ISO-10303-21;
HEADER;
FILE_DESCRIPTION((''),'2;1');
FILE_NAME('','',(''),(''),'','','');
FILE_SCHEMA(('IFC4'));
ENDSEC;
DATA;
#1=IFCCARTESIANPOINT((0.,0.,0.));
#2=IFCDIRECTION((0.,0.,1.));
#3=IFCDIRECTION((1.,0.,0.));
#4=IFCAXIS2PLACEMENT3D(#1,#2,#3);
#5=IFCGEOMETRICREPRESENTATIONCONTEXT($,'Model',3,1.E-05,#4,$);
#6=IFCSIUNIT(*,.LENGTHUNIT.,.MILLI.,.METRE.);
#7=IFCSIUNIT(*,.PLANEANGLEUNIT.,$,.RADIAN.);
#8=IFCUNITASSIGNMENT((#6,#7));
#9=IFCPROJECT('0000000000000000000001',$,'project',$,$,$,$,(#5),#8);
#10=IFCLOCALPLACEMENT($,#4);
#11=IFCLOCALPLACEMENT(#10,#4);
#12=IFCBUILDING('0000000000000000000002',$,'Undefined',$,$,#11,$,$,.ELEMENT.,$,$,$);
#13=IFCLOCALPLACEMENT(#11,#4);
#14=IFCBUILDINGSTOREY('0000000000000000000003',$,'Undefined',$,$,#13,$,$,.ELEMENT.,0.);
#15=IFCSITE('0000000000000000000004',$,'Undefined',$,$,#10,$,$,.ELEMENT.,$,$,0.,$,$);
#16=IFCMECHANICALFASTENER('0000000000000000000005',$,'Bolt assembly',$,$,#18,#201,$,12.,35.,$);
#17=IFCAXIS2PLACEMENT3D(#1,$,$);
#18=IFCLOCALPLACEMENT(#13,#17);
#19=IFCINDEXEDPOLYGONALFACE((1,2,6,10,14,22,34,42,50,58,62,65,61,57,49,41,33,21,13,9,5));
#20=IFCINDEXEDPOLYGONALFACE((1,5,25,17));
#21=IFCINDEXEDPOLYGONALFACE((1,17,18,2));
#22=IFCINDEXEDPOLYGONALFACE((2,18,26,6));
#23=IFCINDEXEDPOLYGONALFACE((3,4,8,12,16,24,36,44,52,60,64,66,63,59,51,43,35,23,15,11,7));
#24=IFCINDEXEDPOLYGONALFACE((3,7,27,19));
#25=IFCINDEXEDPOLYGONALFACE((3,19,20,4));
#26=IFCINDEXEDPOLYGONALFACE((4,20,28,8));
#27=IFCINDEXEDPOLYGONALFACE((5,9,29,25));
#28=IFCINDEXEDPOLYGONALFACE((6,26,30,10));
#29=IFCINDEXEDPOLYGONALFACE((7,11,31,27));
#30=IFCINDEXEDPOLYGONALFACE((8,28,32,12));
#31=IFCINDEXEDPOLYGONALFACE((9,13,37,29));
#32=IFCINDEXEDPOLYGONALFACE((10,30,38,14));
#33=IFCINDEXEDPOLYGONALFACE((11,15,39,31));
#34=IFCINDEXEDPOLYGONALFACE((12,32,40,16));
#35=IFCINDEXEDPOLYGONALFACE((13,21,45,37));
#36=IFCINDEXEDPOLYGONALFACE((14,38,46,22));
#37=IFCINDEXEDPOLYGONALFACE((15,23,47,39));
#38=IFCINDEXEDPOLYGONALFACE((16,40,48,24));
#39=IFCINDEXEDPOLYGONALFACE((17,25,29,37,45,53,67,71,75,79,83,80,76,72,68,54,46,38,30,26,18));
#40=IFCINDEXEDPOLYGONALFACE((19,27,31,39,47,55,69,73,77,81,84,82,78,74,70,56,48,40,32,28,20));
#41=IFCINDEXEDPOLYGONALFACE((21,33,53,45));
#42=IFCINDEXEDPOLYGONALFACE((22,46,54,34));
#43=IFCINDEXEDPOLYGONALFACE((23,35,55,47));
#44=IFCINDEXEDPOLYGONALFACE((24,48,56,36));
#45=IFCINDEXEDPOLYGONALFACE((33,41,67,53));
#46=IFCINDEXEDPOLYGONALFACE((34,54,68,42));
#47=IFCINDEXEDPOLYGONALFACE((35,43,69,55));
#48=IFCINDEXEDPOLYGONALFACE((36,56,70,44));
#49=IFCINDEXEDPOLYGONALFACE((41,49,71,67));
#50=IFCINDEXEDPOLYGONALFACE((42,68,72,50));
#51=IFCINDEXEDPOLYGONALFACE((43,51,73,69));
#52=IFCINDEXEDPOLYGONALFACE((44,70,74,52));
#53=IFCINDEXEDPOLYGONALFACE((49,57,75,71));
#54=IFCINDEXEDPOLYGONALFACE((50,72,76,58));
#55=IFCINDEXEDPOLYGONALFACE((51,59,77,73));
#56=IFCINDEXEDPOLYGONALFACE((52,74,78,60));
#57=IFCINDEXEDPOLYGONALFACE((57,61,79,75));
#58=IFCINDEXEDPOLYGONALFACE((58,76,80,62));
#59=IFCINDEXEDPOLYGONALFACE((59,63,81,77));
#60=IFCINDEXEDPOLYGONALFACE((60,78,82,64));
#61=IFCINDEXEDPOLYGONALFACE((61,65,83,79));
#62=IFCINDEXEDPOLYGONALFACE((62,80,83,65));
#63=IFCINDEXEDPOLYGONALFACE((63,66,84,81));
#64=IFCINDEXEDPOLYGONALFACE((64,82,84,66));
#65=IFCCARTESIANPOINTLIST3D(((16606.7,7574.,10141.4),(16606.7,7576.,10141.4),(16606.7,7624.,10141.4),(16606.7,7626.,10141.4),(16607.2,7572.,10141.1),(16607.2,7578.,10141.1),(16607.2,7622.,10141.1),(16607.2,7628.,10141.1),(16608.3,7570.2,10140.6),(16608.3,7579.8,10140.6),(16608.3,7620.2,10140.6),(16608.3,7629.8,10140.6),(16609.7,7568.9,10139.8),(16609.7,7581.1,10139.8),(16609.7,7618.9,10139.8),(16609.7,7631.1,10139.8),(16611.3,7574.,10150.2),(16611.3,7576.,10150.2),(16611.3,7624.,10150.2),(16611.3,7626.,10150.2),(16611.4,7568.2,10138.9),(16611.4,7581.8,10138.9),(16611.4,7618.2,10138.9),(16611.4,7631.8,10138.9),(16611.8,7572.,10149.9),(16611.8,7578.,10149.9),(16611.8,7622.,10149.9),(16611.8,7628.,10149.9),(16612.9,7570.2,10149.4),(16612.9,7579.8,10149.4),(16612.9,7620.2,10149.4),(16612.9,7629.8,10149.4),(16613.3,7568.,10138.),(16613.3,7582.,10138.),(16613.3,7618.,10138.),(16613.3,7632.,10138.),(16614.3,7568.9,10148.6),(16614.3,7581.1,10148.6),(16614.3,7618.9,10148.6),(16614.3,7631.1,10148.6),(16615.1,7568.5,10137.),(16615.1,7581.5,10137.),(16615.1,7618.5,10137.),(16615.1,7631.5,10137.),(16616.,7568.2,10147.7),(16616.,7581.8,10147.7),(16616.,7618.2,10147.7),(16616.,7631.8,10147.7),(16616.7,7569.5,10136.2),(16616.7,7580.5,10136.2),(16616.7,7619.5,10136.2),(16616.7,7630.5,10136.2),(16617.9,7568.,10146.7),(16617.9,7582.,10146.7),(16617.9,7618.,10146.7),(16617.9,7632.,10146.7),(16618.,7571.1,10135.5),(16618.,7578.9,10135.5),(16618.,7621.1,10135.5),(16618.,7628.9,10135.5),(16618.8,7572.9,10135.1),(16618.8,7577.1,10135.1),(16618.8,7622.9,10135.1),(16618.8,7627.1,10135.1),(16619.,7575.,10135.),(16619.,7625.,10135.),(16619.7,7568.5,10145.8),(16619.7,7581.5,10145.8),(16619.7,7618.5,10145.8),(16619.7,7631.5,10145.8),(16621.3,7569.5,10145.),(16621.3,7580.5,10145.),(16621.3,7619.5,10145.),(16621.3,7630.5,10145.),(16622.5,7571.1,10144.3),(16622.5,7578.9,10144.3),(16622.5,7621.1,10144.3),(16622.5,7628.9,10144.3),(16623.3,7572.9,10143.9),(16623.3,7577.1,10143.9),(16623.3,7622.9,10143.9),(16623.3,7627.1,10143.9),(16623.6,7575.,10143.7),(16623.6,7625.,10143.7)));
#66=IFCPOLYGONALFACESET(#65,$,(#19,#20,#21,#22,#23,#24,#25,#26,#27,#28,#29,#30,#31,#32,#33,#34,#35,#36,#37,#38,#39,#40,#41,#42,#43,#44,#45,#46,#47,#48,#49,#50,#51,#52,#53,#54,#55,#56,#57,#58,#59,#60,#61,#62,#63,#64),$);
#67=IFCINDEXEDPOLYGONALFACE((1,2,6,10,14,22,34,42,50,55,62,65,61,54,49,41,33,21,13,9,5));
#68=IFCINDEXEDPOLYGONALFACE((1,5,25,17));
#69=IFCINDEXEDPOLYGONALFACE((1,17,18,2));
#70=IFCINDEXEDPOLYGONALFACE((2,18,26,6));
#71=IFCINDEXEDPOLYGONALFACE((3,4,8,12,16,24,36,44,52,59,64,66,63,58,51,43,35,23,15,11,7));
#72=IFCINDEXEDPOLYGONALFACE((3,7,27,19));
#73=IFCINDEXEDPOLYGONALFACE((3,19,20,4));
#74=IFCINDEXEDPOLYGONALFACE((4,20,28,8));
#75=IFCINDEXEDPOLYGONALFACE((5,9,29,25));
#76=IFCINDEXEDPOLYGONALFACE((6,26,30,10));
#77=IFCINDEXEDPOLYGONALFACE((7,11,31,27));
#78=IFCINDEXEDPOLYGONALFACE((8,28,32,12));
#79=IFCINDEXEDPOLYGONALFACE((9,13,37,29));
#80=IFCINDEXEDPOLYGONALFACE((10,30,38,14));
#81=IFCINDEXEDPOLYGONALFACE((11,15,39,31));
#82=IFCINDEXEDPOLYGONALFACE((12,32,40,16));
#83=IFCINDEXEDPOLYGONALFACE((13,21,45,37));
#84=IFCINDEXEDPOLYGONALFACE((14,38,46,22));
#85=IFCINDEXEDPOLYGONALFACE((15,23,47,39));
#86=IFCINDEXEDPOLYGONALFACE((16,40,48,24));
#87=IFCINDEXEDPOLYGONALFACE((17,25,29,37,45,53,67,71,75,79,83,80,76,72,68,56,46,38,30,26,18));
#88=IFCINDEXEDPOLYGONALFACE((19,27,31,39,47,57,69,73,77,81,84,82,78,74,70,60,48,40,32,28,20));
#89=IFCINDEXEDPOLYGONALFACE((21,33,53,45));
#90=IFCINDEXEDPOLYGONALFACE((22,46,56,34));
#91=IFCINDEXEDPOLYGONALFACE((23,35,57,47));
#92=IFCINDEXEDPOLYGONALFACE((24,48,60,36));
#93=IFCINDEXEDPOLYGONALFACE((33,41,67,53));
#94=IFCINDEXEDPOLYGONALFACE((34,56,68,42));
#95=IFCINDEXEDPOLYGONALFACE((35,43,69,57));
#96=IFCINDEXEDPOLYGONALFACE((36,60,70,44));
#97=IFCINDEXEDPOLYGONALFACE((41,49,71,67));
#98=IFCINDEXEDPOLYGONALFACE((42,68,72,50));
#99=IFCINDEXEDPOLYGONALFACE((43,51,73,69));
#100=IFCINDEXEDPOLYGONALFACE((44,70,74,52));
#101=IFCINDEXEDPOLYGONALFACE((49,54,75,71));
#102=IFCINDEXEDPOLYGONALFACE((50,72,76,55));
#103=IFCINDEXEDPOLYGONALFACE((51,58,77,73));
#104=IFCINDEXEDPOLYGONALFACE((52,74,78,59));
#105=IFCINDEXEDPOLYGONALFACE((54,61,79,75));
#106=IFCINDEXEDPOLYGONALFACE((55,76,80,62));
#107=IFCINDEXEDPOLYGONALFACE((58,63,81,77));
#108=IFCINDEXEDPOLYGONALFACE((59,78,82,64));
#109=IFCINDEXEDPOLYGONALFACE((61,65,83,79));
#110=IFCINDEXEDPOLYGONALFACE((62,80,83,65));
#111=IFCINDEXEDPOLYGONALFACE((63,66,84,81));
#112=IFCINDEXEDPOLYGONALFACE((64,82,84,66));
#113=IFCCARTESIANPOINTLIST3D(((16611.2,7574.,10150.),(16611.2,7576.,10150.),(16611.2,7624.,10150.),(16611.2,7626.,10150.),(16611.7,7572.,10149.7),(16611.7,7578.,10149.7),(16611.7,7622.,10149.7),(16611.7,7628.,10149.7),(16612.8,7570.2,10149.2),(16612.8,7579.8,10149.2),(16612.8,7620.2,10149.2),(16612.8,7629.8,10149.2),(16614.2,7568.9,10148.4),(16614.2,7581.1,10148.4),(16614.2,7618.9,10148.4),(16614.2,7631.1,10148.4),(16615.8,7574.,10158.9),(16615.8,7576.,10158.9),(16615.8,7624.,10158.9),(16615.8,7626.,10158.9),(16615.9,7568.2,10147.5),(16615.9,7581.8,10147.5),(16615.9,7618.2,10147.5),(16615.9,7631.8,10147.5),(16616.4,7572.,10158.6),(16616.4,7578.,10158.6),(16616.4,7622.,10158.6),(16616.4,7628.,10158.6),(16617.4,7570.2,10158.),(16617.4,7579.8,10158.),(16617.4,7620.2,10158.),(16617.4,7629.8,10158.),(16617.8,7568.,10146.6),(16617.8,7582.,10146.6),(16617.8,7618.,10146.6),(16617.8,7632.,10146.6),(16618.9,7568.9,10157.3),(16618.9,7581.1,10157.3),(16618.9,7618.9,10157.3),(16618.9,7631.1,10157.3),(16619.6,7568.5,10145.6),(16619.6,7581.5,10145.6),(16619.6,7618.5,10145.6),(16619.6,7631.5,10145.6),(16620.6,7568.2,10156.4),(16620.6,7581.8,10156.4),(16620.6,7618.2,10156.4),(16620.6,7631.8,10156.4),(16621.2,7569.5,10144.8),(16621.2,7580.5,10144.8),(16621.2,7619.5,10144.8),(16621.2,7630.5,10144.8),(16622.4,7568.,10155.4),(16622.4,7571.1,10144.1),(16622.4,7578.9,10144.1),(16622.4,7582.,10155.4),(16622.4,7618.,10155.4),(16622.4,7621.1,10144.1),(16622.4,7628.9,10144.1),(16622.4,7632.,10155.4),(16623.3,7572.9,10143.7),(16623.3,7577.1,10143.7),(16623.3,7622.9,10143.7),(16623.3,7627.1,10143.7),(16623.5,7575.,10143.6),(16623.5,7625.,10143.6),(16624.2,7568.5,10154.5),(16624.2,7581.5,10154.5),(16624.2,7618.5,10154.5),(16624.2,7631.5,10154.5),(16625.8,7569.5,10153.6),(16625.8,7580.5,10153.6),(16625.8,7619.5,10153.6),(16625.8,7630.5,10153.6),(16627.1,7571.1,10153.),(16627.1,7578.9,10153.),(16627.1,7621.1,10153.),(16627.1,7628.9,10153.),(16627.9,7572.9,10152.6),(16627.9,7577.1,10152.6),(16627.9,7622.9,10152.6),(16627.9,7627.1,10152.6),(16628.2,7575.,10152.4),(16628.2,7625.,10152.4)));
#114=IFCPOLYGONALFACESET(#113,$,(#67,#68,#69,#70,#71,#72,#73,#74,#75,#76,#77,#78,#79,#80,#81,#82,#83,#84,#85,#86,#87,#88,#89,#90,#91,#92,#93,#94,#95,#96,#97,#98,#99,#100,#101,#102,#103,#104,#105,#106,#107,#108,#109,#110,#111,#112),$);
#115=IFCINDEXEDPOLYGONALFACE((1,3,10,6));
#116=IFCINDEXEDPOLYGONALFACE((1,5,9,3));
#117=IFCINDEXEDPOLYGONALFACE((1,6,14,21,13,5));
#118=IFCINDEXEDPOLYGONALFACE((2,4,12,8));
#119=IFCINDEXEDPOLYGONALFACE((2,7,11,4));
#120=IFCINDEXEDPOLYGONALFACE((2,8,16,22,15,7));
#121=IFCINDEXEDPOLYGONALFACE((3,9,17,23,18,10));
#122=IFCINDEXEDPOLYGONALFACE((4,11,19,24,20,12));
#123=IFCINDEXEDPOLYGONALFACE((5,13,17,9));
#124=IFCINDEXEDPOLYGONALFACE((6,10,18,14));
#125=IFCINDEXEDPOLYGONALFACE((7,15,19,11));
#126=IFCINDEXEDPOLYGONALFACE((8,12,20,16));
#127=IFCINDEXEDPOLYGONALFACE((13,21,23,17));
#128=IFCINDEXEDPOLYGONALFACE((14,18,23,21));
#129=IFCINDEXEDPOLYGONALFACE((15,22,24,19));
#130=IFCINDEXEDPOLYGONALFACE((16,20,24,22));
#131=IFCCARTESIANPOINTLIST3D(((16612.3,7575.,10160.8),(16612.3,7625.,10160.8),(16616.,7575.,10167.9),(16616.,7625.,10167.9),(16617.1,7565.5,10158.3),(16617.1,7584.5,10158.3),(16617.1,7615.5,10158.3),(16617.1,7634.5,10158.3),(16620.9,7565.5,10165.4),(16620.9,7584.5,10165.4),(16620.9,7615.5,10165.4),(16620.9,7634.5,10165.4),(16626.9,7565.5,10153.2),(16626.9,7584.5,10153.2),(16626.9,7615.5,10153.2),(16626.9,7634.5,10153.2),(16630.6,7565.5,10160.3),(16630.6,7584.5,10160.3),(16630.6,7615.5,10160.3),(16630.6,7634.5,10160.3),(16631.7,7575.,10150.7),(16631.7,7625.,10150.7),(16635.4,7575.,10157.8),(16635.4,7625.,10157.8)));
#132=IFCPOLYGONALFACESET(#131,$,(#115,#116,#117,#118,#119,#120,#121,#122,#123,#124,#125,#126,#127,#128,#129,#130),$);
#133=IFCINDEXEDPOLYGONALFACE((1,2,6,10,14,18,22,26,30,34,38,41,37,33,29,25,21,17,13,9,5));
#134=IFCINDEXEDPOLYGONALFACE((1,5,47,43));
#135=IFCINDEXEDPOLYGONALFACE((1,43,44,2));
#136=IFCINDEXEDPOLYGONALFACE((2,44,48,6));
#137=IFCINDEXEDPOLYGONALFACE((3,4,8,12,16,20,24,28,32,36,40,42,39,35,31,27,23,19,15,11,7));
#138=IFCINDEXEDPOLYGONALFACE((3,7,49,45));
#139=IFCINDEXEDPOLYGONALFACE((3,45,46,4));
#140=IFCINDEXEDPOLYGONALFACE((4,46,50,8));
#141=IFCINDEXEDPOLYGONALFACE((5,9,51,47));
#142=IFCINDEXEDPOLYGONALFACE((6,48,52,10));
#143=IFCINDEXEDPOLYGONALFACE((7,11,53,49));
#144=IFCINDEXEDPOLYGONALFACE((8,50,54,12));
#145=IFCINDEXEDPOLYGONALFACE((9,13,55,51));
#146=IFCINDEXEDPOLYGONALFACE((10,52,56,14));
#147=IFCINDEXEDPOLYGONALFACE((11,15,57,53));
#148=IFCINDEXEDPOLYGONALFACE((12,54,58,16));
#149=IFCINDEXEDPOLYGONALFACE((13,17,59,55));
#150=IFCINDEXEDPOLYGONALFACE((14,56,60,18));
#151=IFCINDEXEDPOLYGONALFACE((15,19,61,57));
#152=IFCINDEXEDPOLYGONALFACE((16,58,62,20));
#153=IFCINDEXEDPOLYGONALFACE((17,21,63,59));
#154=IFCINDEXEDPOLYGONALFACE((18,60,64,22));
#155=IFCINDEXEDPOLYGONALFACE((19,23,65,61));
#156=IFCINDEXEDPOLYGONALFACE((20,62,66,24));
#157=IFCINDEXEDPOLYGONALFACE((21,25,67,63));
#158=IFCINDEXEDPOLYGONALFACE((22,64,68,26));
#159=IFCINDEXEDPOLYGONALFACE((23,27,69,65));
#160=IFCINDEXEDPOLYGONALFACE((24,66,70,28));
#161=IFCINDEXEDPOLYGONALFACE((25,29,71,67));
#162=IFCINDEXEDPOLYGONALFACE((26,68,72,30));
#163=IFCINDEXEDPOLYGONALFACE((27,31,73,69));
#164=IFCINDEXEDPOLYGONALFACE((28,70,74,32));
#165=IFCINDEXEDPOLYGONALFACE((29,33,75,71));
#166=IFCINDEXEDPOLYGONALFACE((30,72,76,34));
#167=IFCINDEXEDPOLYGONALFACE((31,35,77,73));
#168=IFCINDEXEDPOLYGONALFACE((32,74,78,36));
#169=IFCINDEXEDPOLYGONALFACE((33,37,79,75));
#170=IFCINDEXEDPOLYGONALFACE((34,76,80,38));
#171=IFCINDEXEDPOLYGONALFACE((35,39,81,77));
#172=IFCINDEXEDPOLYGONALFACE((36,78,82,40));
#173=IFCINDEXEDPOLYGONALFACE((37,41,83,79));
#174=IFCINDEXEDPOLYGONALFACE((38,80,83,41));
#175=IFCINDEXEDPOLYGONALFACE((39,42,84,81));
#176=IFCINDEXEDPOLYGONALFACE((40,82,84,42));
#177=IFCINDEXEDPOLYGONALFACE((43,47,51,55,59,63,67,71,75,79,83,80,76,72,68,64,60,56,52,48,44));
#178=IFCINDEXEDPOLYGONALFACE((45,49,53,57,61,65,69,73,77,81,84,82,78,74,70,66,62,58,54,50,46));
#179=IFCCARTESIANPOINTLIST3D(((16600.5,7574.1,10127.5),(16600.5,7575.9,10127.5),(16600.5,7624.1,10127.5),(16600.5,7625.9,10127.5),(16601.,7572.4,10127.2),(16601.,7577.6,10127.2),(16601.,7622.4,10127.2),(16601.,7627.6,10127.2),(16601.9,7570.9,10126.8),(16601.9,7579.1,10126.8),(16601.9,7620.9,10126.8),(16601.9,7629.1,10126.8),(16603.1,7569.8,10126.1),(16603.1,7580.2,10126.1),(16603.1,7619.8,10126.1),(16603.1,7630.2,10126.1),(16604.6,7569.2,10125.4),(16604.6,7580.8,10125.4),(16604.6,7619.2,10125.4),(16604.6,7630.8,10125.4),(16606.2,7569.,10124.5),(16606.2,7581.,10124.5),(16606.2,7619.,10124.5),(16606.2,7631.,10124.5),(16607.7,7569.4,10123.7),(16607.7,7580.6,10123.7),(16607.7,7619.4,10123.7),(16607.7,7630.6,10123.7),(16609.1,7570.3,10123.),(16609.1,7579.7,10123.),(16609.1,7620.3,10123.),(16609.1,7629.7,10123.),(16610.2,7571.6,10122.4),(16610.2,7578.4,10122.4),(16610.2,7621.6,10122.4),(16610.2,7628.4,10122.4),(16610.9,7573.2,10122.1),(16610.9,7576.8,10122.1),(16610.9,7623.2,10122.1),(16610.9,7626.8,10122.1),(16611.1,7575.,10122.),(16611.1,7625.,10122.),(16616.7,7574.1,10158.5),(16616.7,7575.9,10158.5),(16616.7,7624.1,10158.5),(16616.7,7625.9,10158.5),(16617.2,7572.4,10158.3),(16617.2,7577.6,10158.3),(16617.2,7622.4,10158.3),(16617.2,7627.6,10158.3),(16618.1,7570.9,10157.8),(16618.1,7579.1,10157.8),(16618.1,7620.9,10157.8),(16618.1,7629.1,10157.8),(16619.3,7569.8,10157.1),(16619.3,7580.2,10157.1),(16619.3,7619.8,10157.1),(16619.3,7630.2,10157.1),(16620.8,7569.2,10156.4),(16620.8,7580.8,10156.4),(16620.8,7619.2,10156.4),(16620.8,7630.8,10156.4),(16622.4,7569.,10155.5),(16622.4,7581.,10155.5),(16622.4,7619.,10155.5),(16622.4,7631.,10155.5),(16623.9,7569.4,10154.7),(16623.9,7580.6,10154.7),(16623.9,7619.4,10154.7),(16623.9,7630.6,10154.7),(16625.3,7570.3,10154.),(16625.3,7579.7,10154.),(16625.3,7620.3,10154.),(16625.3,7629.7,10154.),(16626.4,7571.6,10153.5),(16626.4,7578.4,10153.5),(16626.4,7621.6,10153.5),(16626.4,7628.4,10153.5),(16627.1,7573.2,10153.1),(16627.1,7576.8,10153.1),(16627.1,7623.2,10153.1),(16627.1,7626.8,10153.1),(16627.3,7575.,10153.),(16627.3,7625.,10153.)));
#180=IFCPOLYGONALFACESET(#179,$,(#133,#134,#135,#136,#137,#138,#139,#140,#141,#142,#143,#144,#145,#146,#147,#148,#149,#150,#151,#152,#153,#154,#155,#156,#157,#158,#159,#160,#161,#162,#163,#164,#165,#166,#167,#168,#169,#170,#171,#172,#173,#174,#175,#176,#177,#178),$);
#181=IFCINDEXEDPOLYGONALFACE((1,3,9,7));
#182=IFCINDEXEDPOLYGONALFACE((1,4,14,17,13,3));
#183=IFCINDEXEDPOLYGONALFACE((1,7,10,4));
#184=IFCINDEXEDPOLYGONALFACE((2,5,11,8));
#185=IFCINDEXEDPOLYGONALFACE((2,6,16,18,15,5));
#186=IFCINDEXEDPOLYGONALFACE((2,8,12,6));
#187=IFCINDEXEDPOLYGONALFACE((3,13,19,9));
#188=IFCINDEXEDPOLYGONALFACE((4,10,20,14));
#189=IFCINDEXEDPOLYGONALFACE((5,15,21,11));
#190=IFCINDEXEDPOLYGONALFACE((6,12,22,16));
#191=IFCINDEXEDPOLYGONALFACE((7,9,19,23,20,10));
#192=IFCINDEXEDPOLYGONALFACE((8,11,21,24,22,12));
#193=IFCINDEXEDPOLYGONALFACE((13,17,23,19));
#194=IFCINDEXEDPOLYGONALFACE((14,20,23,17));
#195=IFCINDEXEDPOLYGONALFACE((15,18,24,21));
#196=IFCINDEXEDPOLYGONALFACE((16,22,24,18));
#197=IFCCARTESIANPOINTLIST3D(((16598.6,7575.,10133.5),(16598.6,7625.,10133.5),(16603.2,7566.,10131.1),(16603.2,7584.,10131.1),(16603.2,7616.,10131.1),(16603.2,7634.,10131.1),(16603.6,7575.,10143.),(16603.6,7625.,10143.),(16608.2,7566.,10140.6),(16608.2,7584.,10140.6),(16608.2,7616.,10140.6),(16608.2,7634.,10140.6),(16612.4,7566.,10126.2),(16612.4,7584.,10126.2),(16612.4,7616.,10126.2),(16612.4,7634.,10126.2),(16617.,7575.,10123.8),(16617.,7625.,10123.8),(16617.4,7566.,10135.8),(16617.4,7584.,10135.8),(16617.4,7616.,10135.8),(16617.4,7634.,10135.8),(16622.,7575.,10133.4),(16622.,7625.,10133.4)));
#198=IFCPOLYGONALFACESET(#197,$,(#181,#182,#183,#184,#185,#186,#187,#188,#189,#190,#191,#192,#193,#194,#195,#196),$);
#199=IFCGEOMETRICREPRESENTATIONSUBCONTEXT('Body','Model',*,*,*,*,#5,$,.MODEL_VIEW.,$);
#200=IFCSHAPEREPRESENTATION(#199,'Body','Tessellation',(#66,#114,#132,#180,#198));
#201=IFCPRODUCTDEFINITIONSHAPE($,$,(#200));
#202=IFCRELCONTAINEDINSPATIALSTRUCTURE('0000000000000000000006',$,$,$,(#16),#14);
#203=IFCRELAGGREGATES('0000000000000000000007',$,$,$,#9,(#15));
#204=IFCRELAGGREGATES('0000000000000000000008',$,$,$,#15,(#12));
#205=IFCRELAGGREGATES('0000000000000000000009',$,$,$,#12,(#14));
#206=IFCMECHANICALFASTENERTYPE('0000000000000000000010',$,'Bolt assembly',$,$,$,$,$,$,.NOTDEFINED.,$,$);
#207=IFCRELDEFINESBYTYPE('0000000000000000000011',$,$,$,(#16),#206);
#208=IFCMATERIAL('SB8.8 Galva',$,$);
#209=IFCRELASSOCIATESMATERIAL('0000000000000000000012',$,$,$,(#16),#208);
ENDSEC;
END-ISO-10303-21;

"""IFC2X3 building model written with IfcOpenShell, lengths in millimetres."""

from ifc_helpers import new_model, si_unit, frame, origin_with_axes, origin_2d_with_axis, place, context, subcontext, project, spatial, polyline, circle, outline, extrude, source, transform, mapped, material, type_object, element, save


model = new_model("IFC2X3")

# Units and contexts
model_context = context("Model", 3, precision=1e-05, world=origin_with_axes())
body_context = subcontext(model_context, "Body", "Model", "MODEL_VIEW")
ifc_project = project(units=[si_unit("LENGTHUNIT", "METRE", prefix="MILLI"), si_unit("PLANEANGLEUNIT", "RADIAN")], contexts=[model_context])

# Site, building, storey
site_placement = place(None, origin_with_axes())
site = spatial("IfcSite", under=ifc_project, at=site_placement, Name="Undefined", CompositionType="ELEMENT", RefElevation=0.0)
building_placement = place(site_placement, origin_with_axes())
building = spatial("IfcBuilding", under=site, at=building_placement, Name="Undefined", CompositionType="ELEMENT")
storey_placement = place(building_placement, origin_with_axes())
storey = spatial("IfcBuildingStorey", under=building, at=storey_placement, Name="Undefined", CompositionType="ELEMENT", Elevation=0.0)

# Mechanical fastener
mechanical_fastener_type = type_object("IfcMechanicalFastenerType", Name="Bolt assembly")
ifc_material_1 = material(Name="SB8.8 Galva")
shared_shape_1 = source(origin_with_axes(), body_context, "Body", "SweptSolid", [
    extrude(circle(Radius=7.0, at=origin_2d_with_axis()), frame((0.0, -0.1, 0.0), z_axis=(0.0, 1.0, 0.0), x_axis=(1.0, 0.0, 0.0)), (0.0, 0.0, 1.0), 9.9),
    extrude(circle(Radius=7.0, at=origin_2d_with_axis()), frame((0.0, -9.9, 0.0), z_axis=(0.0, 1.0, 0.0), x_axis=(1.0, 0.0, 0.0)), (0.0, 0.0, 1.0), 10.0),
    extrude(outline(polyline([(11.0, 0.0), (5.5, 9.5), (-5.5, 9.5), (-11.0, 0.0), (-5.5, -9.5), (5.5, -9.5), (11.0, 0.0)])), frame((0.0, -18.0, 0.0), z_axis=(0.0, 1.0, 0.0), x_axis=(1.0, 0.0, 0.0)), (0.0, 0.0, 1.0), 8.0),
    extrude(circle(Radius=6.0, at=origin_2d_with_axis()), frame((0.0, -10.0, 0.0), z_axis=(0.0, 1.0, 0.0), x_axis=(1.0, 0.0, 0.0)), (0.0, 0.0, 1.0), 35.0),
    extrude(outline(polyline([(10.4, 0.0), (5.2, 9.0), (-5.2, 9.0), (-10.4, 0.0), (-5.2, -9.0), (5.2, -9.0), (10.4, 0.0)])), frame((0.0, 9.8, 0.0), z_axis=(0.0, 1.0, 0.0), x_axis=(1.0, 0.0, 0.0)), (0.0, 0.0, 1.0), 10.8),
])
for number, where, z_axis, x_axis, name in (
    (1, (16617.4, 7600.0, 10146.9), (0.0, 1.0, 0.0), (0.886082, 0.0, -0.463529), "Bolt assembly"),
):
    element("IfcMechanicalFastener", number, at=place(storey_placement, frame(where, z_axis=z_axis, x_axis=x_axis)), inside=storey, type_object=mechanical_fastener_type, material=ifc_material_1, Name=name, NominalDiameter=12.0, NominalLength=35.0, context=body_context, shape_type="MappedRepresentation", body=[
        mapped(shared_shape_1, transform((0.0, 0.0, -25.0))),
        mapped(shared_shape_1, transform((0.0, 0.0, 25.0))),
    ])

save(model, "model.ifc")
